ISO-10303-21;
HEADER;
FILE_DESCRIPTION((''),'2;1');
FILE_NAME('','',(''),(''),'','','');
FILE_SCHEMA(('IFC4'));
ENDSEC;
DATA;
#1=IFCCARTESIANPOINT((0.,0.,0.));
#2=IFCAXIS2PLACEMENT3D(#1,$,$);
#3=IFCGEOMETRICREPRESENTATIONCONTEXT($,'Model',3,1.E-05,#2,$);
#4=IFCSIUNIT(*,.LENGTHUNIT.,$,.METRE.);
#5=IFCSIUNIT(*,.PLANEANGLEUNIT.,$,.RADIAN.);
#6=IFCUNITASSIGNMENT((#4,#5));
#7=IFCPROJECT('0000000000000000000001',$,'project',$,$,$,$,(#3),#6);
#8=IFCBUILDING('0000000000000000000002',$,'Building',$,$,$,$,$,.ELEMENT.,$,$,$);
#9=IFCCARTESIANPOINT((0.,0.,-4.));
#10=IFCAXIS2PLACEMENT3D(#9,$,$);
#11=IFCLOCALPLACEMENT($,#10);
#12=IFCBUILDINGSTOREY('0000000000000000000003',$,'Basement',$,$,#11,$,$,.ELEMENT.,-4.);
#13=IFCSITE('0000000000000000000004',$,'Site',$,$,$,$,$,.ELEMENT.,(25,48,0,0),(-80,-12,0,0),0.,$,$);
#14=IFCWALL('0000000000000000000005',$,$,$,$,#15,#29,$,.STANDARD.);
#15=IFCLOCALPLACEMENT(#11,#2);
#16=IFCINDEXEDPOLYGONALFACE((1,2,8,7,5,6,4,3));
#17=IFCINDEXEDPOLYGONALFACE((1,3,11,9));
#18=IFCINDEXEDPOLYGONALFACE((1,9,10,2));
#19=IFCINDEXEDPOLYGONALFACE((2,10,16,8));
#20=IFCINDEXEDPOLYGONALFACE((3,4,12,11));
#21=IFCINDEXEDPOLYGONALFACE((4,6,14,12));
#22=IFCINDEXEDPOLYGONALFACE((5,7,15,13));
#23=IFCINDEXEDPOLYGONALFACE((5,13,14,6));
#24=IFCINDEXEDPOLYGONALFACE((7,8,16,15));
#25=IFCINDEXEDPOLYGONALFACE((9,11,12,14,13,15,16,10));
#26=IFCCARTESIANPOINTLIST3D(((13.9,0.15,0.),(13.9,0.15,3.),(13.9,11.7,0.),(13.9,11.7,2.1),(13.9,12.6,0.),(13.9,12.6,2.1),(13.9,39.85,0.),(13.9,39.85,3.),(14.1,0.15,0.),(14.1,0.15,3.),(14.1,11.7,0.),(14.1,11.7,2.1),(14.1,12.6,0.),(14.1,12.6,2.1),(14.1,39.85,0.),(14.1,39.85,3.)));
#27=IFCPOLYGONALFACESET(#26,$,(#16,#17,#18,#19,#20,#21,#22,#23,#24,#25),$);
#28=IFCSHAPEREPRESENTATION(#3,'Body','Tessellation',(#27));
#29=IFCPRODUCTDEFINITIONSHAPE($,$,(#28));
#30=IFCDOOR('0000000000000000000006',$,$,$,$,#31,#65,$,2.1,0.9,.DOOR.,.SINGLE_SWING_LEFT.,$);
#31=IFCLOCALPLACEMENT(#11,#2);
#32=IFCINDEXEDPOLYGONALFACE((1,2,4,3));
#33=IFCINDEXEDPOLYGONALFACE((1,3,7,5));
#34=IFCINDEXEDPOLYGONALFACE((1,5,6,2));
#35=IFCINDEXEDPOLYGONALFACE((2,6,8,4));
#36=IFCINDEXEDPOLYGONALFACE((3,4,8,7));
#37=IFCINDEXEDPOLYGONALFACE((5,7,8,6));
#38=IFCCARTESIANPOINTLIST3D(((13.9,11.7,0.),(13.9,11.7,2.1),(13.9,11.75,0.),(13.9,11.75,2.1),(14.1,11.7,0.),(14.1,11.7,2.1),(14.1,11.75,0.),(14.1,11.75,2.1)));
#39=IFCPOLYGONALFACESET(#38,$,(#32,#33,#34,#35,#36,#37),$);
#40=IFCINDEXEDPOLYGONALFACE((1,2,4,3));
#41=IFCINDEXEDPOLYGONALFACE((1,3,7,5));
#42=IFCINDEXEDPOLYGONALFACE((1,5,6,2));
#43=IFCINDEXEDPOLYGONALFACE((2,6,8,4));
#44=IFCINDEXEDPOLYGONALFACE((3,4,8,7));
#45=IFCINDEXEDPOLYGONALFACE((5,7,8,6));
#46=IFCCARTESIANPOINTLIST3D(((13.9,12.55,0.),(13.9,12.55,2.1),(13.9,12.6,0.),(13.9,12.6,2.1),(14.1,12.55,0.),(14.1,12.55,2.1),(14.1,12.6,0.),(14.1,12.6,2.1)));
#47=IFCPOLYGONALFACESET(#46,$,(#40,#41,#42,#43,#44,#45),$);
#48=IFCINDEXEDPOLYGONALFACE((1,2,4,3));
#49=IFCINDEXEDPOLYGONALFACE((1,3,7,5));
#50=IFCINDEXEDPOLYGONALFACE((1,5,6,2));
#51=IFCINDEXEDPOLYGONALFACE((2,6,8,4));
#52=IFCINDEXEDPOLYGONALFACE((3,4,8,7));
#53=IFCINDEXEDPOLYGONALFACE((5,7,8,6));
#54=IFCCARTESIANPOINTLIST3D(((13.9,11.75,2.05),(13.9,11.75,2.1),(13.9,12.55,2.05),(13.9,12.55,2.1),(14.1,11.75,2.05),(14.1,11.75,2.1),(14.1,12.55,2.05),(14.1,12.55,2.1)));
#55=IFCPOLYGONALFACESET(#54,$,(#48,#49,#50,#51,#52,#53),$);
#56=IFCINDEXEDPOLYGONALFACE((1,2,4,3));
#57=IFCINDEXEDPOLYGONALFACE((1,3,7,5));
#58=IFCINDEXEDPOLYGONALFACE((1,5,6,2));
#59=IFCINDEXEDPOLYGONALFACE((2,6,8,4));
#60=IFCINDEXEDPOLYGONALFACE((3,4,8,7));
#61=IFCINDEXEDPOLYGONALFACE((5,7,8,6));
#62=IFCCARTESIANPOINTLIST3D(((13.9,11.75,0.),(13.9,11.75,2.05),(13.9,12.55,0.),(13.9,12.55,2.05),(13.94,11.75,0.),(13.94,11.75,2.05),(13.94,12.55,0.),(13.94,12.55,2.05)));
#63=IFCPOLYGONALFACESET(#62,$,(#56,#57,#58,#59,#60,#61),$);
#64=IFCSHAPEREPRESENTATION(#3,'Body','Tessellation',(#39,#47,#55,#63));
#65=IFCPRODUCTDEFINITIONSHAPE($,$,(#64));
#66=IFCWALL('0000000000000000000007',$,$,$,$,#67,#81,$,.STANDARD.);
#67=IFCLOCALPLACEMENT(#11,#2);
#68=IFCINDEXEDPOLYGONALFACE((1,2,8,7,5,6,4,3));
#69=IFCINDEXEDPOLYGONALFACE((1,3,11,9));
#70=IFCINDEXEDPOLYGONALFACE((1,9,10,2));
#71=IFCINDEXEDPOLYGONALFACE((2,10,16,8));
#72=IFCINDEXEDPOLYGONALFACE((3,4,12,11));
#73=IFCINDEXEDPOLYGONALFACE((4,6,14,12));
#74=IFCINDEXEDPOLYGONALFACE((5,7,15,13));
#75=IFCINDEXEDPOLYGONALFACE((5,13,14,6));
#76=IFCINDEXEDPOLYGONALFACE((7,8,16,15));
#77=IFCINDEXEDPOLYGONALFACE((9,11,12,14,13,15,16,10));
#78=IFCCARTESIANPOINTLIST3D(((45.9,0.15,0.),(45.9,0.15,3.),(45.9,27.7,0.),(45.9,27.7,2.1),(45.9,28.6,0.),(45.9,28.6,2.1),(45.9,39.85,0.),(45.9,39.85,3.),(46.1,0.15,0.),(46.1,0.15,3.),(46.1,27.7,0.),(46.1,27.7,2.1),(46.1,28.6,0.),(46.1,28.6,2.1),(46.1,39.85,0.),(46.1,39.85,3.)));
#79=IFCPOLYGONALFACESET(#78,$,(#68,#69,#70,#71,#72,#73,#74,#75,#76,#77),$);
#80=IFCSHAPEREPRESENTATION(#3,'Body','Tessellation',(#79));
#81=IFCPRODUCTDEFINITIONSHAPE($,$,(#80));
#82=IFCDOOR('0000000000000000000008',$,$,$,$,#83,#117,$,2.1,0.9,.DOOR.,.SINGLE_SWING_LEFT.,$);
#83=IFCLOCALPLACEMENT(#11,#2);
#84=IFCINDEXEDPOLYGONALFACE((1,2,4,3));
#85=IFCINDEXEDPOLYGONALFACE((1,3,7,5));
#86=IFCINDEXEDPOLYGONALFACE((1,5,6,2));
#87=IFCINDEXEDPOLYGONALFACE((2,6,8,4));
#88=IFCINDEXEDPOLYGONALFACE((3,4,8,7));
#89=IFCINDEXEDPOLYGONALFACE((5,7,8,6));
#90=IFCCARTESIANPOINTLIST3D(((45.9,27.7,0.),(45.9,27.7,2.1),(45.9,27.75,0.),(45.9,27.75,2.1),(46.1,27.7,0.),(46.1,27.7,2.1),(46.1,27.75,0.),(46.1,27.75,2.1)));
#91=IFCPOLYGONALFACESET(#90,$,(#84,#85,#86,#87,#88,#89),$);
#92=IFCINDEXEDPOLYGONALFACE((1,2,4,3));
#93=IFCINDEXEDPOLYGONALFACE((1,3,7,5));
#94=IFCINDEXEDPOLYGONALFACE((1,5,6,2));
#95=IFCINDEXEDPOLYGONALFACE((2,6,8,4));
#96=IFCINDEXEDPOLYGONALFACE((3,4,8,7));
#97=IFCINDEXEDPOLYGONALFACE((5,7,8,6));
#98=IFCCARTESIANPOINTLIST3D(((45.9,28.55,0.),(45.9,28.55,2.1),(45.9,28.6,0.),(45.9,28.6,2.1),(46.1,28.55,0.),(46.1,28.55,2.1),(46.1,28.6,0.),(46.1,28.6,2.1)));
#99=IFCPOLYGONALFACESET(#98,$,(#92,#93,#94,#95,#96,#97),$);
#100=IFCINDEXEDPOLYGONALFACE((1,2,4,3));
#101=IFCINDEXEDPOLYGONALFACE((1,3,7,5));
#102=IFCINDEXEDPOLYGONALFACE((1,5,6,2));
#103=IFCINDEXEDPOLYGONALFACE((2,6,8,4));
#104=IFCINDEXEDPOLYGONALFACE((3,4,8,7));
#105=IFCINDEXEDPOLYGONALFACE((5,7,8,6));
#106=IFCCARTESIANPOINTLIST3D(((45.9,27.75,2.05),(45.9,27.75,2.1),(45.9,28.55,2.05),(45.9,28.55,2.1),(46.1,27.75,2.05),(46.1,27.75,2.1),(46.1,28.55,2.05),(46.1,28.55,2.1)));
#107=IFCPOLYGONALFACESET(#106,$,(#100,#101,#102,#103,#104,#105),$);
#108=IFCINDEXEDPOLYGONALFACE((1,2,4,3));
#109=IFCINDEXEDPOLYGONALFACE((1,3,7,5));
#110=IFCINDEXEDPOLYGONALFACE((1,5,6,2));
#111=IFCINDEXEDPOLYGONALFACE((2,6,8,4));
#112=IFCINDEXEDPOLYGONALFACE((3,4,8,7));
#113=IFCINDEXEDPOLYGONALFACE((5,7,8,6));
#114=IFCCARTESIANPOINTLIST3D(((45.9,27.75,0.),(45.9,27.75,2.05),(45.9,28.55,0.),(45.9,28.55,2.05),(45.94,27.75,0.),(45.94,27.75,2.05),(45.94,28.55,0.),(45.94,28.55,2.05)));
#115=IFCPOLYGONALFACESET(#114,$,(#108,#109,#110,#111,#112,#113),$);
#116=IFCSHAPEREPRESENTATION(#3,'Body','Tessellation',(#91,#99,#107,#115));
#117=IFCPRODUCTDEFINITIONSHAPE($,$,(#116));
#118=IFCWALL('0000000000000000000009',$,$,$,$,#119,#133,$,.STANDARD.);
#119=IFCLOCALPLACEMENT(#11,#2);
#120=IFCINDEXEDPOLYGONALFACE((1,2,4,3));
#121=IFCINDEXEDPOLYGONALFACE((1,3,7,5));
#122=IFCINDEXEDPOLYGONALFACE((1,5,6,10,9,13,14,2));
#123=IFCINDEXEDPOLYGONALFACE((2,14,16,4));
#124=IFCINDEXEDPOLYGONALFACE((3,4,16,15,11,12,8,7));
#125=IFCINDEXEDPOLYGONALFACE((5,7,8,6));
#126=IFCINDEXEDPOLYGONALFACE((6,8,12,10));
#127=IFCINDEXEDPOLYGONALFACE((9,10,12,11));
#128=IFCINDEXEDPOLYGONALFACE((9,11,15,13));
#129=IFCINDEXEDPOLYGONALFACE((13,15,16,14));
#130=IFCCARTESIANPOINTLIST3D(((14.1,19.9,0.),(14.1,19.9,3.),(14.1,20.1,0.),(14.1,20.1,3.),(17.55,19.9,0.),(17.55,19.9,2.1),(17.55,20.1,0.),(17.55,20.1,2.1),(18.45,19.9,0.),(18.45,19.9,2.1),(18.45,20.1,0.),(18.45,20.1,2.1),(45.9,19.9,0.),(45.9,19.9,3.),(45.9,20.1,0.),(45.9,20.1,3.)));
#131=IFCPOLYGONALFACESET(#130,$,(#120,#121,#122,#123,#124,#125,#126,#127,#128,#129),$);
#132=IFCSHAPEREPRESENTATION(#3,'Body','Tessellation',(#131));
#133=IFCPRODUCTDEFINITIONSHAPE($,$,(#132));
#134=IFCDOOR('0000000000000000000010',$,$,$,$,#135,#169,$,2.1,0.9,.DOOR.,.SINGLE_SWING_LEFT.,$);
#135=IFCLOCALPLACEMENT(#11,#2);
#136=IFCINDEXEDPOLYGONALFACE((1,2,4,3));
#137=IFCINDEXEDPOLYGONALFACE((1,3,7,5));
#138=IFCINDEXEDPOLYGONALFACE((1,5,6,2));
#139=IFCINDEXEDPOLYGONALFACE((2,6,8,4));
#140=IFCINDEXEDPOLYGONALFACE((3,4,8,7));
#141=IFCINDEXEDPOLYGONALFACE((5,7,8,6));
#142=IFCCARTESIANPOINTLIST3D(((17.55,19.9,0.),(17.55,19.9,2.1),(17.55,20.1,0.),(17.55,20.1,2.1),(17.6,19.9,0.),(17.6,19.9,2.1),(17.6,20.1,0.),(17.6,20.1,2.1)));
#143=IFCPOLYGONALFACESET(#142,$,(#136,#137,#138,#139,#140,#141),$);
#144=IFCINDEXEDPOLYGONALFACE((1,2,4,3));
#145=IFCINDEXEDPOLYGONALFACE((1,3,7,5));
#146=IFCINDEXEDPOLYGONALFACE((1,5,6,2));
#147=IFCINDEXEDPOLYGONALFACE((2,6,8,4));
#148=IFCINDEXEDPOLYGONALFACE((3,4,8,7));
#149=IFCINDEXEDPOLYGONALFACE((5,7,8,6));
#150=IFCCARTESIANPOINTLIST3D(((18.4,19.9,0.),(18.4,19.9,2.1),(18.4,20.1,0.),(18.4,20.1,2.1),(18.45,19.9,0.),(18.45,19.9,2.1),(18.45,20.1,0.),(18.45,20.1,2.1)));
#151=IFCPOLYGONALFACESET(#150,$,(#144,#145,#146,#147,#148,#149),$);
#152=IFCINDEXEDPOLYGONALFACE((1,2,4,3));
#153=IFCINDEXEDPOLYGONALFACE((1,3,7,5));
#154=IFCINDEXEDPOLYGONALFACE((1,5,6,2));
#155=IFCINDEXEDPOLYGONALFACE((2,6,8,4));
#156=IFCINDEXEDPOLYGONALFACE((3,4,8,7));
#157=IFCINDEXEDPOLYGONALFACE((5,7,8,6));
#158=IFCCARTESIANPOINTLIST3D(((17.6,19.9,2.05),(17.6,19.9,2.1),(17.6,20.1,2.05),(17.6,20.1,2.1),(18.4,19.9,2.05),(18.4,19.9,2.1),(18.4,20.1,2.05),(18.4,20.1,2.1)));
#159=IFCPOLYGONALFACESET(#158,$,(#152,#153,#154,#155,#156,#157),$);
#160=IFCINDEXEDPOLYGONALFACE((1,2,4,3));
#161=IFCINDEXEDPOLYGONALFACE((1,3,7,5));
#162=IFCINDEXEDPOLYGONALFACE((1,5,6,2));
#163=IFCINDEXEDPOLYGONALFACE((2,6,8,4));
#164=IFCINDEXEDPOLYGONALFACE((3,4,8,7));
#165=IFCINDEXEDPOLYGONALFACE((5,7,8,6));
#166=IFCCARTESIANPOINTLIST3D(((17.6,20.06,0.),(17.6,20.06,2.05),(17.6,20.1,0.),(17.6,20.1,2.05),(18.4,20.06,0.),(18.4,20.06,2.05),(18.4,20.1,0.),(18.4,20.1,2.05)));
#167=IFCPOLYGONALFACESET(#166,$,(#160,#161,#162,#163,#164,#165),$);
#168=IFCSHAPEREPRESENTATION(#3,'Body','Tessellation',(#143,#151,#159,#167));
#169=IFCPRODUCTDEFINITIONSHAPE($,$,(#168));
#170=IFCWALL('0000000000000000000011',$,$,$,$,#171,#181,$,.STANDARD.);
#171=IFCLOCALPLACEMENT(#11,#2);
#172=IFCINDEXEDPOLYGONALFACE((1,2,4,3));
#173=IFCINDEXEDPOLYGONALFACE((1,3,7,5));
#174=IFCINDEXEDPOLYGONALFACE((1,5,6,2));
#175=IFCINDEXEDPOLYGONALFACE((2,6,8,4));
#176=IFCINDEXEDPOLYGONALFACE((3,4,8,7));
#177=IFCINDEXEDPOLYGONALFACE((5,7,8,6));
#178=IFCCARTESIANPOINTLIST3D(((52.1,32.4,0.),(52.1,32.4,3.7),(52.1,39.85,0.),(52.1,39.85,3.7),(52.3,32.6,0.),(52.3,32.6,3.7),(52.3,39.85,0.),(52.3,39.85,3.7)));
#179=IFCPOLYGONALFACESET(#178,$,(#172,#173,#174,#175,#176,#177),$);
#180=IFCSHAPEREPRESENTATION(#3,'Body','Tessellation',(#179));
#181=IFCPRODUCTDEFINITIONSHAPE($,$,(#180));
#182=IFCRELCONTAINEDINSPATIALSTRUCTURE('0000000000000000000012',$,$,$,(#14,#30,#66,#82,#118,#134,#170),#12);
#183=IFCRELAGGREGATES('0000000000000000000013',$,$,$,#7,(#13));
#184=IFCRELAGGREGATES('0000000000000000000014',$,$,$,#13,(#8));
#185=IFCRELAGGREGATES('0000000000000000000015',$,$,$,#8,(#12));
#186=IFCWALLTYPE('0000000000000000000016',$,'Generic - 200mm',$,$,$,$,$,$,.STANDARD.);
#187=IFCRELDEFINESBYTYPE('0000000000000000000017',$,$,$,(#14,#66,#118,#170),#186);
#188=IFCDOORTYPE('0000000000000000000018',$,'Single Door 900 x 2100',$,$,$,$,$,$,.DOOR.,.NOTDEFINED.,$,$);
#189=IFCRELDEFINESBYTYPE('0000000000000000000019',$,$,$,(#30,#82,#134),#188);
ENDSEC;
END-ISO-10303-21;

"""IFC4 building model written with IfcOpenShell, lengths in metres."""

from ifc_helpers import new_model, si_unit, frame, frame_2d, origin, origin_with_axes, origin_2d, place, context, project, spatial, polyline, rectangle, outline, extrude, type_object, element, fill, save


model = new_model("IFC4")

# Units and contexts
model_context = context("Model", 3, precision=1e-05, world=origin())
ifc_project = project(units=[si_unit("LENGTHUNIT", "METRE"), si_unit("PLANEANGLEUNIT", "RADIAN")], contexts=[model_context])

# Site, building, storey
site = spatial("IfcSite", under=ifc_project, Name="Site", CompositionType="ELEMENT", RefLatitude=(25, 48, 0, 0), RefLongitude=(-80, -12, 0, 0), RefElevation=0.0)
building = spatial("IfcBuilding", under=site, Name="Building", CompositionType="ELEMENT")
storey_placement = place(None, frame((0.0, 0.0, -4.0)))
storey = spatial("IfcBuildingStorey", under=building, at=storey_placement, Name="Basement", CompositionType="ELEMENT", Elevation=-4.0)

# Walls, openings, doors
wall_type_1 = type_object("IfcWallType", Name="Generic - 200mm", PredefinedType="STANDARD")
wall_1_placement = place(None, frame((14.0, 0.15, -4.0), z_axis=(0.0, 0.0, 1.0), x_axis=(0.0, 1.0, 0.0)))
wall_1 = element("IfcWall", 1, at=wall_1_placement, inside=storey, type_object=wall_type_1, PredefinedType="STANDARD", context=model_context, shape_type="SweptSolid", body=[
    extrude(rectangle(XDim=39.7, YDim=0.2, at=frame_2d((19.85, 0.0))), origin(), (0.0, 0.0, 1.0), 3.0),
])
opening_1_placement = place(wall_1_placement, frame((12.0, 0.0, 0.0), z_axis=(0.0, 0.0, 1.0), x_axis=(1.0, 0.0, 0.0)))
opening_1 = element("IfcOpeningElement", 2, at=opening_1_placement, cuts=wall_1, PredefinedType="OPENING", context=model_context, shape_type="SweptSolid", body=[
    extrude(rectangle(XDim=0.9, YDim=0.202, at=origin_2d()), origin(), (0.0, 0.0, 1.0), 2.1),
])
door_type = type_object("IfcDoorType", Name="Single Door 900 x 2100", OperationType="NOTDEFINED", PredefinedType="DOOR")
door_1_placement = place(opening_1_placement, origin_with_axes())
door_1 = element("IfcDoor", 3, at=door_1_placement, inside=storey, type_object=door_type, OperationType="SINGLE_SWING_LEFT", OverallHeight=2.1, OverallWidth=0.9, PredefinedType="DOOR", context=model_context, shape_type="SweptSolid", body=[
    extrude(rectangle(XDim=0.05, YDim=0.2, at=frame_2d((-0.425, 0.0))), origin(), (0.0, 0.0, 1.0), 2.1),
    extrude(rectangle(XDim=0.05, YDim=0.2, at=frame_2d((0.425, 0.0))), origin(), (0.0, 0.0, 1.0), 2.1),
    extrude(rectangle(XDim=0.8, YDim=0.2, at=origin_2d()), frame((0.0, 0.0, 2.05)), (0.0, 0.0, 1.0), 0.05),
    extrude(rectangle(XDim=0.8, YDim=0.04, at=frame_2d((0.0, 0.08))), origin(), (0.0, 0.0, 1.0), 2.05),
])
fill(opening_1, door_1)
wall_2_placement = place(None, frame((46.0, 0.15, -4.0), z_axis=(0.0, 0.0, 1.0), x_axis=(0.0, 1.0, 0.0)))
wall_2 = element("IfcWall", 4, at=wall_2_placement, inside=storey, type_object=wall_type_1, PredefinedType="STANDARD", context=model_context, shape_type="SweptSolid", body=[
    extrude(rectangle(XDim=39.7, YDim=0.2, at=frame_2d((19.85, 0.0))), origin(), (0.0, 0.0, 1.0), 3.0),
])
opening_2_placement = place(wall_2_placement, frame((28.0, 0.0, 0.0), z_axis=(0.0, 0.0, 1.0), x_axis=(1.0, 0.0, 0.0)))
opening_2 = element("IfcOpeningElement", 5, at=opening_2_placement, cuts=wall_2, PredefinedType="OPENING", context=model_context, shape_type="SweptSolid", body=[
    extrude(rectangle(XDim=0.9, YDim=0.202, at=origin_2d()), origin(), (0.0, 0.0, 1.0), 2.1),
])
door_2_placement = place(opening_2_placement, origin_with_axes())
door_2 = element("IfcDoor", 6, at=door_2_placement, inside=storey, type_object=door_type, OperationType="SINGLE_SWING_LEFT", OverallHeight=2.1, OverallWidth=0.9, PredefinedType="DOOR", context=model_context, shape_type="SweptSolid", body=[
    extrude(rectangle(XDim=0.05, YDim=0.2, at=frame_2d((-0.425, 0.0))), origin(), (0.0, 0.0, 1.0), 2.1),
    extrude(rectangle(XDim=0.05, YDim=0.2, at=frame_2d((0.425, 0.0))), origin(), (0.0, 0.0, 1.0), 2.1),
    extrude(rectangle(XDim=0.8, YDim=0.2, at=origin_2d()), frame((0.0, 0.0, 2.05)), (0.0, 0.0, 1.0), 0.05),
    extrude(rectangle(XDim=0.8, YDim=0.04, at=frame_2d((0.0, 0.08))), origin(), (0.0, 0.0, 1.0), 2.05),
])
fill(opening_2, door_2)
wall_3_placement = place(None, frame((14.0, 20.0, -4.0), z_axis=(0.0, 0.0, 1.0), x_axis=(1.0, 0.0, 0.0)))
wall_3 = element("IfcWall", 7, at=wall_3_placement, inside=storey, type_object=wall_type_1, PredefinedType="STANDARD", context=model_context, shape_type="SweptSolid", body=[
    extrude(outline(polyline([(0.1, -0.1), (31.9, -0.1), (31.9, 0.1), (0.1, 0.1), (0.1, -0.1)])), origin(), (0.0, 0.0, 1.0), 3.0),
])
opening_3_placement = place(wall_3_placement, frame((4.0, 0.0, 0.0), z_axis=(0.0, 0.0, 1.0), x_axis=(1.0, 0.0, 0.0)))
opening_3 = element("IfcOpeningElement", 8, at=opening_3_placement, cuts=wall_3, PredefinedType="OPENING", context=model_context, shape_type="SweptSolid", body=[
    extrude(rectangle(XDim=0.9, YDim=0.202, at=origin_2d()), origin(), (0.0, 0.0, 1.0), 2.1),
])
door_3_placement = place(opening_3_placement, origin_with_axes())
door_3 = element("IfcDoor", 9, at=door_3_placement, inside=storey, type_object=door_type, OperationType="SINGLE_SWING_LEFT", OverallHeight=2.1, OverallWidth=0.9, PredefinedType="DOOR", context=model_context, shape_type="SweptSolid", body=[
    extrude(rectangle(XDim=0.05, YDim=0.2, at=frame_2d((-0.425, 0.0))), origin(), (0.0, 0.0, 1.0), 2.1),
    extrude(rectangle(XDim=0.05, YDim=0.2, at=frame_2d((0.425, 0.0))), origin(), (0.0, 0.0, 1.0), 2.1),
    extrude(rectangle(XDim=0.8, YDim=0.2, at=origin_2d()), frame((0.0, 0.0, 2.05)), (0.0, 0.0, 1.0), 0.05),
    extrude(rectangle(XDim=0.8, YDim=0.04, at=frame_2d((0.0, 0.08))), origin(), (0.0, 0.0, 1.0), 2.05),
])
fill(opening_3, door_3)

# Wall
wall_4_placement = place(None, frame((52.2, 32.5, -4.0), z_axis=(0.0, 0.0, 1.0), x_axis=(0.0, 1.0, 0.0)))
element("IfcWall", 10, at=wall_4_placement, inside=storey, type_object=wall_type_1, PredefinedType="STANDARD", context=model_context, shape_type="SweptSolid", body=[
    extrude(outline(polyline([(0.1, -0.1), (7.35, -0.1), (7.35, 0.1), (-0.1, 0.1), (0.1, -0.1)])), origin(), (0.0, 0.0, 1.0), 3.7),
])

save(model, "model.ifc")
